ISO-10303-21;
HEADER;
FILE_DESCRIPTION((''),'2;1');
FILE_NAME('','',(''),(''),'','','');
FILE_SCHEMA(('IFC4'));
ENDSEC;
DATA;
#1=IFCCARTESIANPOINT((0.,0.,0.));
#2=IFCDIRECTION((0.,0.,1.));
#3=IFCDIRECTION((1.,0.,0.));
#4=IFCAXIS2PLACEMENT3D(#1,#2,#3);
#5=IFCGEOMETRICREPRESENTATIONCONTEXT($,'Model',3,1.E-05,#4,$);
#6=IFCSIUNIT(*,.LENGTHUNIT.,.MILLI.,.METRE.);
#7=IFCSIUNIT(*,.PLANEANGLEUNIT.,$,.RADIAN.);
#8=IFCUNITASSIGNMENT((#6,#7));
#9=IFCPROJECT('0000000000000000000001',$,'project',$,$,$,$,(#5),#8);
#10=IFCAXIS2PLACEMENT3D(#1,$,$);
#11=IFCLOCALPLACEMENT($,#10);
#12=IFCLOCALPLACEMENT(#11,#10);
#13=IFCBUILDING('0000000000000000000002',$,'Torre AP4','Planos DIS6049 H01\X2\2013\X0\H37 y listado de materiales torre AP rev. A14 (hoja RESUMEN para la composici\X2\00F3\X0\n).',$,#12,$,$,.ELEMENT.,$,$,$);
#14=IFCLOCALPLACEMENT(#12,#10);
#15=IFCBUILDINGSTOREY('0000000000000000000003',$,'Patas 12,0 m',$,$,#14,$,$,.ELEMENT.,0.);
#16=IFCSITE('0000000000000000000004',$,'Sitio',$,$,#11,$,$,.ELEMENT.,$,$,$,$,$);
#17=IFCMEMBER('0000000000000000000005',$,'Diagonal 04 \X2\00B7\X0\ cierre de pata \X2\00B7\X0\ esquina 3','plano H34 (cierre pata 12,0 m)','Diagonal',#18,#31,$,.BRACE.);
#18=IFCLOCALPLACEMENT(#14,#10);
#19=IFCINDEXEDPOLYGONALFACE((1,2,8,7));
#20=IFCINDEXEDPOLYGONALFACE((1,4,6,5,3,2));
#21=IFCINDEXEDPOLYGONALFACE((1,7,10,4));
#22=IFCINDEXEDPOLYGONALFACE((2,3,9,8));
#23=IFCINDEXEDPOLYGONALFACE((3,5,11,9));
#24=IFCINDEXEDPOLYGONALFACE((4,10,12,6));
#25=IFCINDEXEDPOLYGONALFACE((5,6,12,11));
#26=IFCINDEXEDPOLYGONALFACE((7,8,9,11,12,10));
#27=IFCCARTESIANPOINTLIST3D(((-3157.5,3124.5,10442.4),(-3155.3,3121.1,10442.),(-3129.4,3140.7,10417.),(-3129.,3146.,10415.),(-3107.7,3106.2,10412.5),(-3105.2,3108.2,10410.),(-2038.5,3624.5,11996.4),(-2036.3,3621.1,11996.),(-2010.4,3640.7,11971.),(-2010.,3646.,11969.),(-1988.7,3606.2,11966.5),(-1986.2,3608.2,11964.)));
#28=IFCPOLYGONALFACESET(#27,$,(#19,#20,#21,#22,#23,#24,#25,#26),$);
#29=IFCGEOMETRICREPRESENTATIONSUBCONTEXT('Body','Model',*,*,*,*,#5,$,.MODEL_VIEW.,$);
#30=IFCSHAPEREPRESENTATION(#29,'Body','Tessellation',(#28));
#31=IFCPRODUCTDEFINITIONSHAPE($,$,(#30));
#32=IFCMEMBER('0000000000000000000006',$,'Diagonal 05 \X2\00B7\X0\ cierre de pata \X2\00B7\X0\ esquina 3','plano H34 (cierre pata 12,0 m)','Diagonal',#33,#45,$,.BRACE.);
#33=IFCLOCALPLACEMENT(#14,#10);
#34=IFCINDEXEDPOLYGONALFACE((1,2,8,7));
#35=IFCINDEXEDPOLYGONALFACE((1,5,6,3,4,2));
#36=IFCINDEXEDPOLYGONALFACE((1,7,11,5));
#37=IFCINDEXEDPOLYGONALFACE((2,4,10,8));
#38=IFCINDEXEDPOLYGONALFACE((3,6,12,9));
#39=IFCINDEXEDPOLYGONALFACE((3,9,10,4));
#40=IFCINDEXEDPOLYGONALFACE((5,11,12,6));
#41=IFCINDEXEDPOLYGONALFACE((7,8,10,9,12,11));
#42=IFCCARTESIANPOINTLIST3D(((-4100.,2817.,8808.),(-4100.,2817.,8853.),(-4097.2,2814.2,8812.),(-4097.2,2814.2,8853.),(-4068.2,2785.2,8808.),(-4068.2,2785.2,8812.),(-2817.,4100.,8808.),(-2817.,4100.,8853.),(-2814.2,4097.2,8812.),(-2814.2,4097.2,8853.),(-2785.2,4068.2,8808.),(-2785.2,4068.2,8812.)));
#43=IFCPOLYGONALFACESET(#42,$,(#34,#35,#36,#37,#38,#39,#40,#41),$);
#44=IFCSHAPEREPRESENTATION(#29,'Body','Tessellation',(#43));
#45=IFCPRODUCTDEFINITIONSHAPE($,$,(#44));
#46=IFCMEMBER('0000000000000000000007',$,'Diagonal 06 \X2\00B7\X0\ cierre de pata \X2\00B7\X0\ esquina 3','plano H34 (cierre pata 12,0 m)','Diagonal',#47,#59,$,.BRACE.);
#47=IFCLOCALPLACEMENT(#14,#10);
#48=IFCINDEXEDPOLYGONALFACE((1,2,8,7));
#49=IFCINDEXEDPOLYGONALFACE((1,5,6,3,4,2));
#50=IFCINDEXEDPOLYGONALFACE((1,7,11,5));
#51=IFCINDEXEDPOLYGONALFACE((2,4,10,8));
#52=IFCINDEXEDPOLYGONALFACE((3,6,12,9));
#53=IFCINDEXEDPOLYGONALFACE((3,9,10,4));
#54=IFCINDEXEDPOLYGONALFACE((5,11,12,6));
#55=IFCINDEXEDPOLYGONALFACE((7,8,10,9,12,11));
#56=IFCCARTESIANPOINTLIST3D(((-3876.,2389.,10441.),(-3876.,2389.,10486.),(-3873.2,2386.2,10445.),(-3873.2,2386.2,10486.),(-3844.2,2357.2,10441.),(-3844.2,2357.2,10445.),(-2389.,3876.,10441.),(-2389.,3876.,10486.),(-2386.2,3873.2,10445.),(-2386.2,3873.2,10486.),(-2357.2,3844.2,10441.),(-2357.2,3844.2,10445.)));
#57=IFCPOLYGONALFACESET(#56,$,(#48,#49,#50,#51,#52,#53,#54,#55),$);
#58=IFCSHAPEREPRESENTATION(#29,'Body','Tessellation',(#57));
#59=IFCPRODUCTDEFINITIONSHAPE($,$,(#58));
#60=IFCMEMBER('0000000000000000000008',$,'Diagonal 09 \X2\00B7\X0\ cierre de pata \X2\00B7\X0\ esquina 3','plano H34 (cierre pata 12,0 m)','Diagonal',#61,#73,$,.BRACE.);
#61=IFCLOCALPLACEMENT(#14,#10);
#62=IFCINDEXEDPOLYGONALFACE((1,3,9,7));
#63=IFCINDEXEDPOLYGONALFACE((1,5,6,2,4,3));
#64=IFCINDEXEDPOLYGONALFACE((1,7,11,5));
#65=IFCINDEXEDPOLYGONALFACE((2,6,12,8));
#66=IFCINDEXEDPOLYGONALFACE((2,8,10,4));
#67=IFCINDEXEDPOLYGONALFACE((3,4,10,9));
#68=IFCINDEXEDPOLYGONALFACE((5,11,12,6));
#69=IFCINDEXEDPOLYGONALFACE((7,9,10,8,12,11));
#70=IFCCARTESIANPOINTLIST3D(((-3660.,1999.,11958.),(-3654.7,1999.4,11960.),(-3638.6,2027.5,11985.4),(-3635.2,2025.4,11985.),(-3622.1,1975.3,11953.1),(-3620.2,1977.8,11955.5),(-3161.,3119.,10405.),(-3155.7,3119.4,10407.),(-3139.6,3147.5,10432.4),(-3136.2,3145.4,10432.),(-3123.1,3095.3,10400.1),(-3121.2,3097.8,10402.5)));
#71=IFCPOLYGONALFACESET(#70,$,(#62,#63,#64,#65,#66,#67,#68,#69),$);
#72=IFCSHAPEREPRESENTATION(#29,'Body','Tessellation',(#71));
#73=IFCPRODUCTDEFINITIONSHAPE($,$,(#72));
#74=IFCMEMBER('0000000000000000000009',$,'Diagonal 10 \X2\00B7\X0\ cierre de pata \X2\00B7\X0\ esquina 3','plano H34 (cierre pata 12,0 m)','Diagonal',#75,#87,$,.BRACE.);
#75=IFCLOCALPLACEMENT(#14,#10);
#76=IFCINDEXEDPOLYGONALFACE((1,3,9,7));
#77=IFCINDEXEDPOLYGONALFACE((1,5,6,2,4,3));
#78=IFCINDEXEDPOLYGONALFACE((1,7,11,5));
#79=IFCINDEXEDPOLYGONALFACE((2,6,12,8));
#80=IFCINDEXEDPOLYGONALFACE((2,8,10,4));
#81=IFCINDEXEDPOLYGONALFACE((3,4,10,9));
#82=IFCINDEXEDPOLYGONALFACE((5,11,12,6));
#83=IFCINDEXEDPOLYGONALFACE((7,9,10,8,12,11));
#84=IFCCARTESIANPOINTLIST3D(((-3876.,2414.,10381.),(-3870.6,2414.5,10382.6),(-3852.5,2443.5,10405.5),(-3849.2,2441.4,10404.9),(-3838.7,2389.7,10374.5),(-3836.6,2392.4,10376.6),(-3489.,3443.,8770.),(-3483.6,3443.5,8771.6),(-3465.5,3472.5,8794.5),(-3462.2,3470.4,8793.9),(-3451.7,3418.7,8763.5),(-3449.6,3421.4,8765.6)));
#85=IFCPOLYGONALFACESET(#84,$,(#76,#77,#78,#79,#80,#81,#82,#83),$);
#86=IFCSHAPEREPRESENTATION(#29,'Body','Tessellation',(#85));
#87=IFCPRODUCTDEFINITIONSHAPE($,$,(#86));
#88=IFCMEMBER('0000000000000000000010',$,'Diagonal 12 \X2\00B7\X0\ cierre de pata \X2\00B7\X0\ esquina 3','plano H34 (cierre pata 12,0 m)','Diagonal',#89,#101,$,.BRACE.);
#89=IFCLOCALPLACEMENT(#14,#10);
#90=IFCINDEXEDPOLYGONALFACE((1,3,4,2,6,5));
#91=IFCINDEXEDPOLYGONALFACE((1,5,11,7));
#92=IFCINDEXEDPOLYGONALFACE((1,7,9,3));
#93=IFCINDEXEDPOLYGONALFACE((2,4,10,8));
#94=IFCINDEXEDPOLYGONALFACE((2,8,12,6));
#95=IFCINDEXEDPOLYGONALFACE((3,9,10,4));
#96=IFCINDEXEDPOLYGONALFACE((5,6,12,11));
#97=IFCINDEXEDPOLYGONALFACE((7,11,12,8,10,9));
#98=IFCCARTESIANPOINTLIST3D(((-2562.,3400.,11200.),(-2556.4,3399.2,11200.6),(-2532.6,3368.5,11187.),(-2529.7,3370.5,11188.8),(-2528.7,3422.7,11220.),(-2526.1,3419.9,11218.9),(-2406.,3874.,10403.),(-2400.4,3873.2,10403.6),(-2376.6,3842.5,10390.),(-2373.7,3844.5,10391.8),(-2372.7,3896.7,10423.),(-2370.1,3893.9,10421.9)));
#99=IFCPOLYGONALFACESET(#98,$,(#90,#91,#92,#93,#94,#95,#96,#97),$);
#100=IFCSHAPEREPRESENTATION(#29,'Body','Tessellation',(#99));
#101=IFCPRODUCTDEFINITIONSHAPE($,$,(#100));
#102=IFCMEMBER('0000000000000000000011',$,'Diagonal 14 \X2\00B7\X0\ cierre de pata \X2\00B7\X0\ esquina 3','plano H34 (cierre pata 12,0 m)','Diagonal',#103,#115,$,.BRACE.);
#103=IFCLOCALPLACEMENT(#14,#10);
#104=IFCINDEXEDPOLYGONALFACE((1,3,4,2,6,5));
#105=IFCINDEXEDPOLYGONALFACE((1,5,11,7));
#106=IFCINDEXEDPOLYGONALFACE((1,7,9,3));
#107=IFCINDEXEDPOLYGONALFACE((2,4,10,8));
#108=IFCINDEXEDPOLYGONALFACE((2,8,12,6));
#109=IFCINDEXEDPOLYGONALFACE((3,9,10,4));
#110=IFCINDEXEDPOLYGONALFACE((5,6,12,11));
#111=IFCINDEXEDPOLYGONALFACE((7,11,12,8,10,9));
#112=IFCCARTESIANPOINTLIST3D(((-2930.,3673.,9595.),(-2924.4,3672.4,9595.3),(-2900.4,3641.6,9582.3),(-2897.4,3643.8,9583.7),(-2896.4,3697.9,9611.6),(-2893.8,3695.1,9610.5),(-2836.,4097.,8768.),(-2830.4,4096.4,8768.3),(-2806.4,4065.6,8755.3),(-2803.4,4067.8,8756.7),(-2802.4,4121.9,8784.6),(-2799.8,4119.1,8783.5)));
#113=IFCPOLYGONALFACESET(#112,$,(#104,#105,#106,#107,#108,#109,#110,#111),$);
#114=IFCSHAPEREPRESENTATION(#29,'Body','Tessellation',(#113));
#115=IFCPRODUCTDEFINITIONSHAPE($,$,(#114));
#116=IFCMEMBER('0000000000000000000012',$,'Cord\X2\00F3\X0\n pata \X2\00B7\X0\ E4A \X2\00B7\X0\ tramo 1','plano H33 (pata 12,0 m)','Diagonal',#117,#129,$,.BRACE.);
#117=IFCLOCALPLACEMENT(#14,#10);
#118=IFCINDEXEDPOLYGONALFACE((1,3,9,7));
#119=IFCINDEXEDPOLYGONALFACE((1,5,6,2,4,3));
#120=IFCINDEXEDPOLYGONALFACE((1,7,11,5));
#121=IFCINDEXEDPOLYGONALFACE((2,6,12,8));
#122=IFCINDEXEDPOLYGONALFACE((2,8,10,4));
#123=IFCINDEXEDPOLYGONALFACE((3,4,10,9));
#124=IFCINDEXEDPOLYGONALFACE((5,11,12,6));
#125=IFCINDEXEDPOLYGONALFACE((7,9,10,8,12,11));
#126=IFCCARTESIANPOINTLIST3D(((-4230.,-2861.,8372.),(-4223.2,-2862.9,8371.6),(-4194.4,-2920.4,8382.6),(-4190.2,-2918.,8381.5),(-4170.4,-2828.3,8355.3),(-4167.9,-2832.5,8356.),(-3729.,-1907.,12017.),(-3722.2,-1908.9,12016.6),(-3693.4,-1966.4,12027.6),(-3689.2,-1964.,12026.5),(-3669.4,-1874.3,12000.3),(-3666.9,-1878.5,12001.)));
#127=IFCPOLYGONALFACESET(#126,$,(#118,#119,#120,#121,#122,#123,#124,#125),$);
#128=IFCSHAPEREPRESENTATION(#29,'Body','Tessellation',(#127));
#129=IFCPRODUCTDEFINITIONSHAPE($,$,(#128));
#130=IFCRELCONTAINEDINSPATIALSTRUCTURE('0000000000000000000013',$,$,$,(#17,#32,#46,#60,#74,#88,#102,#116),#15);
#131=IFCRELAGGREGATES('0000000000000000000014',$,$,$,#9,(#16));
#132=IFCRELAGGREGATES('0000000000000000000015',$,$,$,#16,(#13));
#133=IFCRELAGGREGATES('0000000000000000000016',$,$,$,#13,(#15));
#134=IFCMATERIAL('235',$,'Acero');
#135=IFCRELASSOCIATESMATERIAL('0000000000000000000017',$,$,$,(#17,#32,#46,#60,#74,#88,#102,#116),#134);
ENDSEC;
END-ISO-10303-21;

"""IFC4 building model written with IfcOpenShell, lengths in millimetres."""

from ifc_helpers import new_model, si_unit, frame, frame_2d, origin, origin_with_axes, place, context, subcontext, project, spatial, l_section, extrude, material, element, save


model = new_model("IFC4")

# Units and contexts
model_context = context("Model", 3, precision=1e-05, world=origin_with_axes())
body_context = subcontext(model_context, "Body", "Model", "MODEL_VIEW")
ifc_project = project(units=[si_unit("LENGTHUNIT", "METRE", prefix="MILLI"), si_unit("PLANEANGLEUNIT", "RADIAN")], contexts=[model_context])

# Site, building, storey
site_placement = place(None, origin())
site = spatial("IfcSite", under=ifc_project, at=site_placement, Name="Sitio", CompositionType="ELEMENT")
building_placement = place(site_placement, origin())
building = spatial("IfcBuilding", under=site, at=building_placement, Name="Torre AP4", Description="Planos DIS6049 H01–H37 y listado de materiales torre AP rev. A14 (hoja RESUMEN para la composición).", CompositionType="ELEMENT")
storey_placement = place(building_placement, origin())
storey = spatial("IfcBuildingStorey", under=building, at=storey_placement, Name="Patas 12,0 m", CompositionType="ELEMENT", Elevation=0.0)

# Members
ifc_material_1 = material(Name="235", Category="Acero")
member_1_placement = place(storey_placement, frame((-2010.0, 3646.0, 11969.0), z_axis=(-0.565391, -0.252632, -0.785181), x_axis=(0.529594, -0.840989, -0.11076)))
element("IfcMember", 1, at=member_1_placement, inside=storey, material=ifc_material_1, Name="Diagonal 04 · cierre de pata · esquina 3", Description="plano H34 (cierre pata 12,0 m)", ObjectType="Diagonal", PredefinedType="BRACE", context=body_context, shape_type="SweptSolid", body=[
    extrude(l_section(Depth=45.0, Width=45.0, Thickness=4.0, at=frame_2d((22.5, 22.5))), None, (0.0, 0.0, 1.0), 1979.2),
])
member_2_placement = place(storey_placement, frame((-2817.0, 4100.0, 8808.0), z_axis=(-0.707107, -0.707107, 0.0), x_axis=(0.707107, -0.707107, 0.0)))
element("IfcMember", 2, at=member_2_placement, inside=storey, material=ifc_material_1, Name="Diagonal 05 · cierre de pata · esquina 3", Description="plano H34 (cierre pata 12,0 m)", ObjectType="Diagonal", PredefinedType="BRACE", context=body_context, shape_type="SweptSolid", body=[
    extrude(l_section(Depth=45.0, Width=45.0, Thickness=4.0, at=frame_2d((22.5, 22.5))), None, (0.0, 0.0, 1.0), 1814.4),
])
member_3_placement = place(storey_placement, frame((-2389.0, 3876.0, 10441.0), z_axis=(-0.707107, -0.707107, 0.0), x_axis=(0.707107, -0.707107, 0.0)))
element("IfcMember", 3, at=member_3_placement, inside=storey, material=ifc_material_1, Name="Diagonal 06 · cierre de pata · esquina 3", Description="plano H34 (cierre pata 12,0 m)", ObjectType="Diagonal", PredefinedType="BRACE", context=body_context, shape_type="SweptSolid", body=[
    extrude(l_section(Depth=45.0, Width=45.0, Thickness=4.0, at=frame_2d((22.5, 22.5))), None, (0.0, 0.0, 1.0), 2102.9),
])
member_4_placement = place(storey_placement, frame((-3161.0, 3119.0, 10405.0), z_axis=(-0.252187, -0.566031, 0.784863), x_axis=(0.842737, -0.527101, -0.109355)))
element("IfcMember", 4, at=member_4_placement, inside=storey, material=ifc_material_1, Name="Diagonal 09 · cierre de pata · esquina 3", Description="plano H34 (cierre pata 12,0 m)", ObjectType="Diagonal", PredefinedType="BRACE", context=body_context, shape_type="SweptSolid", body=[
    extrude(l_section(Depth=45.0, Width=45.0, Thickness=4.0, at=frame_2d((22.5, 22.5))), None, (0.0, 0.0, 1.0), 1978.7),
])
member_5_placement = place(storey_placement, frame((-3489.0, 3443.0, 8770.0), z_axis=(-0.198424, -0.527593, 0.825998), x_axis=(0.829544, -0.539245, -0.145158)))
element("IfcMember", 5, at=member_5_placement, inside=storey, material=ifc_material_1, Name="Diagonal 10 · cierre de pata · esquina 3", Description="plano H34 (cierre pata 12,0 m)", ObjectType="Diagonal", PredefinedType="BRACE", context=body_context, shape_type="SweptSolid", body=[
    extrude(l_section(Depth=45.0, Width=45.0, Thickness=4.0, at=frame_2d((22.5, 22.5))), None, (0.0, 0.0, 1.0), 1950.4),
])
member_6_placement = place(storey_placement, frame((-2406.0, 3874.0, 10403.0), z_axis=(-0.165899, -0.504078, 0.847575), x_axis=(0.652429, -0.700597, -0.288964)))
element("IfcMember", 6, at=member_6_placement, inside=storey, material=ifc_material_1, Name="Diagonal 12 · cierre de pata · esquina 3", Description="plano H34 (cierre pata 12,0 m)", ObjectType="Diagonal", PredefinedType="BRACE", context=body_context, shape_type="SweptSolid", body=[
    extrude(l_section(Depth=45.0, Width=45.0, Thickness=4.0, at=frame_2d((22.5, 22.5))), None, (0.0, 0.0, 1.0), 940.3),
])
member_7_placement = place(storey_placement, frame((-2836.0, 4097.0, 8768.0), z_axis=(-0.100632, -0.453913, 0.885345), x_axis=(0.657818, -0.697959, -0.283071)))
element("IfcMember", 7, at=member_7_placement, inside=storey, material=ifc_material_1, Name="Diagonal 14 · cierre de pata · esquina 3", Description="plano H34 (cierre pata 12,0 m)", ObjectType="Diagonal", PredefinedType="BRACE", context=body_context, shape_type="SweptSolid", body=[
    extrude(l_section(Depth=45.0, Width=45.0, Thickness=4.0, at=frame_2d((22.5, 22.5))), None, (0.0, 0.0, 1.0), 934.1),
])
member_8_placement = place(storey_placement, frame((-3729.0, -1907.0, 12017.0), z_axis=(-0.13181, -0.250991, -0.958973), x_axis=(0.851254, 0.467044, -0.239242)))
element("IfcMember", 8, at=member_8_placement, inside=storey, material=ifc_material_1, Name="Cordón pata · E4A · tramo 1", Description="plano H33 (pata 12,0 m)", ObjectType="Diagonal", PredefinedType="BRACE", context=body_context, shape_type="SweptSolid", body=[
    extrude(l_section(Depth=70.0, Width=70.0, Thickness=5.0, at=frame_2d((35.0, 35.0))), None, (0.0, 0.0, 1.0), 3800.9),
])

save(model, "model.ifc")
